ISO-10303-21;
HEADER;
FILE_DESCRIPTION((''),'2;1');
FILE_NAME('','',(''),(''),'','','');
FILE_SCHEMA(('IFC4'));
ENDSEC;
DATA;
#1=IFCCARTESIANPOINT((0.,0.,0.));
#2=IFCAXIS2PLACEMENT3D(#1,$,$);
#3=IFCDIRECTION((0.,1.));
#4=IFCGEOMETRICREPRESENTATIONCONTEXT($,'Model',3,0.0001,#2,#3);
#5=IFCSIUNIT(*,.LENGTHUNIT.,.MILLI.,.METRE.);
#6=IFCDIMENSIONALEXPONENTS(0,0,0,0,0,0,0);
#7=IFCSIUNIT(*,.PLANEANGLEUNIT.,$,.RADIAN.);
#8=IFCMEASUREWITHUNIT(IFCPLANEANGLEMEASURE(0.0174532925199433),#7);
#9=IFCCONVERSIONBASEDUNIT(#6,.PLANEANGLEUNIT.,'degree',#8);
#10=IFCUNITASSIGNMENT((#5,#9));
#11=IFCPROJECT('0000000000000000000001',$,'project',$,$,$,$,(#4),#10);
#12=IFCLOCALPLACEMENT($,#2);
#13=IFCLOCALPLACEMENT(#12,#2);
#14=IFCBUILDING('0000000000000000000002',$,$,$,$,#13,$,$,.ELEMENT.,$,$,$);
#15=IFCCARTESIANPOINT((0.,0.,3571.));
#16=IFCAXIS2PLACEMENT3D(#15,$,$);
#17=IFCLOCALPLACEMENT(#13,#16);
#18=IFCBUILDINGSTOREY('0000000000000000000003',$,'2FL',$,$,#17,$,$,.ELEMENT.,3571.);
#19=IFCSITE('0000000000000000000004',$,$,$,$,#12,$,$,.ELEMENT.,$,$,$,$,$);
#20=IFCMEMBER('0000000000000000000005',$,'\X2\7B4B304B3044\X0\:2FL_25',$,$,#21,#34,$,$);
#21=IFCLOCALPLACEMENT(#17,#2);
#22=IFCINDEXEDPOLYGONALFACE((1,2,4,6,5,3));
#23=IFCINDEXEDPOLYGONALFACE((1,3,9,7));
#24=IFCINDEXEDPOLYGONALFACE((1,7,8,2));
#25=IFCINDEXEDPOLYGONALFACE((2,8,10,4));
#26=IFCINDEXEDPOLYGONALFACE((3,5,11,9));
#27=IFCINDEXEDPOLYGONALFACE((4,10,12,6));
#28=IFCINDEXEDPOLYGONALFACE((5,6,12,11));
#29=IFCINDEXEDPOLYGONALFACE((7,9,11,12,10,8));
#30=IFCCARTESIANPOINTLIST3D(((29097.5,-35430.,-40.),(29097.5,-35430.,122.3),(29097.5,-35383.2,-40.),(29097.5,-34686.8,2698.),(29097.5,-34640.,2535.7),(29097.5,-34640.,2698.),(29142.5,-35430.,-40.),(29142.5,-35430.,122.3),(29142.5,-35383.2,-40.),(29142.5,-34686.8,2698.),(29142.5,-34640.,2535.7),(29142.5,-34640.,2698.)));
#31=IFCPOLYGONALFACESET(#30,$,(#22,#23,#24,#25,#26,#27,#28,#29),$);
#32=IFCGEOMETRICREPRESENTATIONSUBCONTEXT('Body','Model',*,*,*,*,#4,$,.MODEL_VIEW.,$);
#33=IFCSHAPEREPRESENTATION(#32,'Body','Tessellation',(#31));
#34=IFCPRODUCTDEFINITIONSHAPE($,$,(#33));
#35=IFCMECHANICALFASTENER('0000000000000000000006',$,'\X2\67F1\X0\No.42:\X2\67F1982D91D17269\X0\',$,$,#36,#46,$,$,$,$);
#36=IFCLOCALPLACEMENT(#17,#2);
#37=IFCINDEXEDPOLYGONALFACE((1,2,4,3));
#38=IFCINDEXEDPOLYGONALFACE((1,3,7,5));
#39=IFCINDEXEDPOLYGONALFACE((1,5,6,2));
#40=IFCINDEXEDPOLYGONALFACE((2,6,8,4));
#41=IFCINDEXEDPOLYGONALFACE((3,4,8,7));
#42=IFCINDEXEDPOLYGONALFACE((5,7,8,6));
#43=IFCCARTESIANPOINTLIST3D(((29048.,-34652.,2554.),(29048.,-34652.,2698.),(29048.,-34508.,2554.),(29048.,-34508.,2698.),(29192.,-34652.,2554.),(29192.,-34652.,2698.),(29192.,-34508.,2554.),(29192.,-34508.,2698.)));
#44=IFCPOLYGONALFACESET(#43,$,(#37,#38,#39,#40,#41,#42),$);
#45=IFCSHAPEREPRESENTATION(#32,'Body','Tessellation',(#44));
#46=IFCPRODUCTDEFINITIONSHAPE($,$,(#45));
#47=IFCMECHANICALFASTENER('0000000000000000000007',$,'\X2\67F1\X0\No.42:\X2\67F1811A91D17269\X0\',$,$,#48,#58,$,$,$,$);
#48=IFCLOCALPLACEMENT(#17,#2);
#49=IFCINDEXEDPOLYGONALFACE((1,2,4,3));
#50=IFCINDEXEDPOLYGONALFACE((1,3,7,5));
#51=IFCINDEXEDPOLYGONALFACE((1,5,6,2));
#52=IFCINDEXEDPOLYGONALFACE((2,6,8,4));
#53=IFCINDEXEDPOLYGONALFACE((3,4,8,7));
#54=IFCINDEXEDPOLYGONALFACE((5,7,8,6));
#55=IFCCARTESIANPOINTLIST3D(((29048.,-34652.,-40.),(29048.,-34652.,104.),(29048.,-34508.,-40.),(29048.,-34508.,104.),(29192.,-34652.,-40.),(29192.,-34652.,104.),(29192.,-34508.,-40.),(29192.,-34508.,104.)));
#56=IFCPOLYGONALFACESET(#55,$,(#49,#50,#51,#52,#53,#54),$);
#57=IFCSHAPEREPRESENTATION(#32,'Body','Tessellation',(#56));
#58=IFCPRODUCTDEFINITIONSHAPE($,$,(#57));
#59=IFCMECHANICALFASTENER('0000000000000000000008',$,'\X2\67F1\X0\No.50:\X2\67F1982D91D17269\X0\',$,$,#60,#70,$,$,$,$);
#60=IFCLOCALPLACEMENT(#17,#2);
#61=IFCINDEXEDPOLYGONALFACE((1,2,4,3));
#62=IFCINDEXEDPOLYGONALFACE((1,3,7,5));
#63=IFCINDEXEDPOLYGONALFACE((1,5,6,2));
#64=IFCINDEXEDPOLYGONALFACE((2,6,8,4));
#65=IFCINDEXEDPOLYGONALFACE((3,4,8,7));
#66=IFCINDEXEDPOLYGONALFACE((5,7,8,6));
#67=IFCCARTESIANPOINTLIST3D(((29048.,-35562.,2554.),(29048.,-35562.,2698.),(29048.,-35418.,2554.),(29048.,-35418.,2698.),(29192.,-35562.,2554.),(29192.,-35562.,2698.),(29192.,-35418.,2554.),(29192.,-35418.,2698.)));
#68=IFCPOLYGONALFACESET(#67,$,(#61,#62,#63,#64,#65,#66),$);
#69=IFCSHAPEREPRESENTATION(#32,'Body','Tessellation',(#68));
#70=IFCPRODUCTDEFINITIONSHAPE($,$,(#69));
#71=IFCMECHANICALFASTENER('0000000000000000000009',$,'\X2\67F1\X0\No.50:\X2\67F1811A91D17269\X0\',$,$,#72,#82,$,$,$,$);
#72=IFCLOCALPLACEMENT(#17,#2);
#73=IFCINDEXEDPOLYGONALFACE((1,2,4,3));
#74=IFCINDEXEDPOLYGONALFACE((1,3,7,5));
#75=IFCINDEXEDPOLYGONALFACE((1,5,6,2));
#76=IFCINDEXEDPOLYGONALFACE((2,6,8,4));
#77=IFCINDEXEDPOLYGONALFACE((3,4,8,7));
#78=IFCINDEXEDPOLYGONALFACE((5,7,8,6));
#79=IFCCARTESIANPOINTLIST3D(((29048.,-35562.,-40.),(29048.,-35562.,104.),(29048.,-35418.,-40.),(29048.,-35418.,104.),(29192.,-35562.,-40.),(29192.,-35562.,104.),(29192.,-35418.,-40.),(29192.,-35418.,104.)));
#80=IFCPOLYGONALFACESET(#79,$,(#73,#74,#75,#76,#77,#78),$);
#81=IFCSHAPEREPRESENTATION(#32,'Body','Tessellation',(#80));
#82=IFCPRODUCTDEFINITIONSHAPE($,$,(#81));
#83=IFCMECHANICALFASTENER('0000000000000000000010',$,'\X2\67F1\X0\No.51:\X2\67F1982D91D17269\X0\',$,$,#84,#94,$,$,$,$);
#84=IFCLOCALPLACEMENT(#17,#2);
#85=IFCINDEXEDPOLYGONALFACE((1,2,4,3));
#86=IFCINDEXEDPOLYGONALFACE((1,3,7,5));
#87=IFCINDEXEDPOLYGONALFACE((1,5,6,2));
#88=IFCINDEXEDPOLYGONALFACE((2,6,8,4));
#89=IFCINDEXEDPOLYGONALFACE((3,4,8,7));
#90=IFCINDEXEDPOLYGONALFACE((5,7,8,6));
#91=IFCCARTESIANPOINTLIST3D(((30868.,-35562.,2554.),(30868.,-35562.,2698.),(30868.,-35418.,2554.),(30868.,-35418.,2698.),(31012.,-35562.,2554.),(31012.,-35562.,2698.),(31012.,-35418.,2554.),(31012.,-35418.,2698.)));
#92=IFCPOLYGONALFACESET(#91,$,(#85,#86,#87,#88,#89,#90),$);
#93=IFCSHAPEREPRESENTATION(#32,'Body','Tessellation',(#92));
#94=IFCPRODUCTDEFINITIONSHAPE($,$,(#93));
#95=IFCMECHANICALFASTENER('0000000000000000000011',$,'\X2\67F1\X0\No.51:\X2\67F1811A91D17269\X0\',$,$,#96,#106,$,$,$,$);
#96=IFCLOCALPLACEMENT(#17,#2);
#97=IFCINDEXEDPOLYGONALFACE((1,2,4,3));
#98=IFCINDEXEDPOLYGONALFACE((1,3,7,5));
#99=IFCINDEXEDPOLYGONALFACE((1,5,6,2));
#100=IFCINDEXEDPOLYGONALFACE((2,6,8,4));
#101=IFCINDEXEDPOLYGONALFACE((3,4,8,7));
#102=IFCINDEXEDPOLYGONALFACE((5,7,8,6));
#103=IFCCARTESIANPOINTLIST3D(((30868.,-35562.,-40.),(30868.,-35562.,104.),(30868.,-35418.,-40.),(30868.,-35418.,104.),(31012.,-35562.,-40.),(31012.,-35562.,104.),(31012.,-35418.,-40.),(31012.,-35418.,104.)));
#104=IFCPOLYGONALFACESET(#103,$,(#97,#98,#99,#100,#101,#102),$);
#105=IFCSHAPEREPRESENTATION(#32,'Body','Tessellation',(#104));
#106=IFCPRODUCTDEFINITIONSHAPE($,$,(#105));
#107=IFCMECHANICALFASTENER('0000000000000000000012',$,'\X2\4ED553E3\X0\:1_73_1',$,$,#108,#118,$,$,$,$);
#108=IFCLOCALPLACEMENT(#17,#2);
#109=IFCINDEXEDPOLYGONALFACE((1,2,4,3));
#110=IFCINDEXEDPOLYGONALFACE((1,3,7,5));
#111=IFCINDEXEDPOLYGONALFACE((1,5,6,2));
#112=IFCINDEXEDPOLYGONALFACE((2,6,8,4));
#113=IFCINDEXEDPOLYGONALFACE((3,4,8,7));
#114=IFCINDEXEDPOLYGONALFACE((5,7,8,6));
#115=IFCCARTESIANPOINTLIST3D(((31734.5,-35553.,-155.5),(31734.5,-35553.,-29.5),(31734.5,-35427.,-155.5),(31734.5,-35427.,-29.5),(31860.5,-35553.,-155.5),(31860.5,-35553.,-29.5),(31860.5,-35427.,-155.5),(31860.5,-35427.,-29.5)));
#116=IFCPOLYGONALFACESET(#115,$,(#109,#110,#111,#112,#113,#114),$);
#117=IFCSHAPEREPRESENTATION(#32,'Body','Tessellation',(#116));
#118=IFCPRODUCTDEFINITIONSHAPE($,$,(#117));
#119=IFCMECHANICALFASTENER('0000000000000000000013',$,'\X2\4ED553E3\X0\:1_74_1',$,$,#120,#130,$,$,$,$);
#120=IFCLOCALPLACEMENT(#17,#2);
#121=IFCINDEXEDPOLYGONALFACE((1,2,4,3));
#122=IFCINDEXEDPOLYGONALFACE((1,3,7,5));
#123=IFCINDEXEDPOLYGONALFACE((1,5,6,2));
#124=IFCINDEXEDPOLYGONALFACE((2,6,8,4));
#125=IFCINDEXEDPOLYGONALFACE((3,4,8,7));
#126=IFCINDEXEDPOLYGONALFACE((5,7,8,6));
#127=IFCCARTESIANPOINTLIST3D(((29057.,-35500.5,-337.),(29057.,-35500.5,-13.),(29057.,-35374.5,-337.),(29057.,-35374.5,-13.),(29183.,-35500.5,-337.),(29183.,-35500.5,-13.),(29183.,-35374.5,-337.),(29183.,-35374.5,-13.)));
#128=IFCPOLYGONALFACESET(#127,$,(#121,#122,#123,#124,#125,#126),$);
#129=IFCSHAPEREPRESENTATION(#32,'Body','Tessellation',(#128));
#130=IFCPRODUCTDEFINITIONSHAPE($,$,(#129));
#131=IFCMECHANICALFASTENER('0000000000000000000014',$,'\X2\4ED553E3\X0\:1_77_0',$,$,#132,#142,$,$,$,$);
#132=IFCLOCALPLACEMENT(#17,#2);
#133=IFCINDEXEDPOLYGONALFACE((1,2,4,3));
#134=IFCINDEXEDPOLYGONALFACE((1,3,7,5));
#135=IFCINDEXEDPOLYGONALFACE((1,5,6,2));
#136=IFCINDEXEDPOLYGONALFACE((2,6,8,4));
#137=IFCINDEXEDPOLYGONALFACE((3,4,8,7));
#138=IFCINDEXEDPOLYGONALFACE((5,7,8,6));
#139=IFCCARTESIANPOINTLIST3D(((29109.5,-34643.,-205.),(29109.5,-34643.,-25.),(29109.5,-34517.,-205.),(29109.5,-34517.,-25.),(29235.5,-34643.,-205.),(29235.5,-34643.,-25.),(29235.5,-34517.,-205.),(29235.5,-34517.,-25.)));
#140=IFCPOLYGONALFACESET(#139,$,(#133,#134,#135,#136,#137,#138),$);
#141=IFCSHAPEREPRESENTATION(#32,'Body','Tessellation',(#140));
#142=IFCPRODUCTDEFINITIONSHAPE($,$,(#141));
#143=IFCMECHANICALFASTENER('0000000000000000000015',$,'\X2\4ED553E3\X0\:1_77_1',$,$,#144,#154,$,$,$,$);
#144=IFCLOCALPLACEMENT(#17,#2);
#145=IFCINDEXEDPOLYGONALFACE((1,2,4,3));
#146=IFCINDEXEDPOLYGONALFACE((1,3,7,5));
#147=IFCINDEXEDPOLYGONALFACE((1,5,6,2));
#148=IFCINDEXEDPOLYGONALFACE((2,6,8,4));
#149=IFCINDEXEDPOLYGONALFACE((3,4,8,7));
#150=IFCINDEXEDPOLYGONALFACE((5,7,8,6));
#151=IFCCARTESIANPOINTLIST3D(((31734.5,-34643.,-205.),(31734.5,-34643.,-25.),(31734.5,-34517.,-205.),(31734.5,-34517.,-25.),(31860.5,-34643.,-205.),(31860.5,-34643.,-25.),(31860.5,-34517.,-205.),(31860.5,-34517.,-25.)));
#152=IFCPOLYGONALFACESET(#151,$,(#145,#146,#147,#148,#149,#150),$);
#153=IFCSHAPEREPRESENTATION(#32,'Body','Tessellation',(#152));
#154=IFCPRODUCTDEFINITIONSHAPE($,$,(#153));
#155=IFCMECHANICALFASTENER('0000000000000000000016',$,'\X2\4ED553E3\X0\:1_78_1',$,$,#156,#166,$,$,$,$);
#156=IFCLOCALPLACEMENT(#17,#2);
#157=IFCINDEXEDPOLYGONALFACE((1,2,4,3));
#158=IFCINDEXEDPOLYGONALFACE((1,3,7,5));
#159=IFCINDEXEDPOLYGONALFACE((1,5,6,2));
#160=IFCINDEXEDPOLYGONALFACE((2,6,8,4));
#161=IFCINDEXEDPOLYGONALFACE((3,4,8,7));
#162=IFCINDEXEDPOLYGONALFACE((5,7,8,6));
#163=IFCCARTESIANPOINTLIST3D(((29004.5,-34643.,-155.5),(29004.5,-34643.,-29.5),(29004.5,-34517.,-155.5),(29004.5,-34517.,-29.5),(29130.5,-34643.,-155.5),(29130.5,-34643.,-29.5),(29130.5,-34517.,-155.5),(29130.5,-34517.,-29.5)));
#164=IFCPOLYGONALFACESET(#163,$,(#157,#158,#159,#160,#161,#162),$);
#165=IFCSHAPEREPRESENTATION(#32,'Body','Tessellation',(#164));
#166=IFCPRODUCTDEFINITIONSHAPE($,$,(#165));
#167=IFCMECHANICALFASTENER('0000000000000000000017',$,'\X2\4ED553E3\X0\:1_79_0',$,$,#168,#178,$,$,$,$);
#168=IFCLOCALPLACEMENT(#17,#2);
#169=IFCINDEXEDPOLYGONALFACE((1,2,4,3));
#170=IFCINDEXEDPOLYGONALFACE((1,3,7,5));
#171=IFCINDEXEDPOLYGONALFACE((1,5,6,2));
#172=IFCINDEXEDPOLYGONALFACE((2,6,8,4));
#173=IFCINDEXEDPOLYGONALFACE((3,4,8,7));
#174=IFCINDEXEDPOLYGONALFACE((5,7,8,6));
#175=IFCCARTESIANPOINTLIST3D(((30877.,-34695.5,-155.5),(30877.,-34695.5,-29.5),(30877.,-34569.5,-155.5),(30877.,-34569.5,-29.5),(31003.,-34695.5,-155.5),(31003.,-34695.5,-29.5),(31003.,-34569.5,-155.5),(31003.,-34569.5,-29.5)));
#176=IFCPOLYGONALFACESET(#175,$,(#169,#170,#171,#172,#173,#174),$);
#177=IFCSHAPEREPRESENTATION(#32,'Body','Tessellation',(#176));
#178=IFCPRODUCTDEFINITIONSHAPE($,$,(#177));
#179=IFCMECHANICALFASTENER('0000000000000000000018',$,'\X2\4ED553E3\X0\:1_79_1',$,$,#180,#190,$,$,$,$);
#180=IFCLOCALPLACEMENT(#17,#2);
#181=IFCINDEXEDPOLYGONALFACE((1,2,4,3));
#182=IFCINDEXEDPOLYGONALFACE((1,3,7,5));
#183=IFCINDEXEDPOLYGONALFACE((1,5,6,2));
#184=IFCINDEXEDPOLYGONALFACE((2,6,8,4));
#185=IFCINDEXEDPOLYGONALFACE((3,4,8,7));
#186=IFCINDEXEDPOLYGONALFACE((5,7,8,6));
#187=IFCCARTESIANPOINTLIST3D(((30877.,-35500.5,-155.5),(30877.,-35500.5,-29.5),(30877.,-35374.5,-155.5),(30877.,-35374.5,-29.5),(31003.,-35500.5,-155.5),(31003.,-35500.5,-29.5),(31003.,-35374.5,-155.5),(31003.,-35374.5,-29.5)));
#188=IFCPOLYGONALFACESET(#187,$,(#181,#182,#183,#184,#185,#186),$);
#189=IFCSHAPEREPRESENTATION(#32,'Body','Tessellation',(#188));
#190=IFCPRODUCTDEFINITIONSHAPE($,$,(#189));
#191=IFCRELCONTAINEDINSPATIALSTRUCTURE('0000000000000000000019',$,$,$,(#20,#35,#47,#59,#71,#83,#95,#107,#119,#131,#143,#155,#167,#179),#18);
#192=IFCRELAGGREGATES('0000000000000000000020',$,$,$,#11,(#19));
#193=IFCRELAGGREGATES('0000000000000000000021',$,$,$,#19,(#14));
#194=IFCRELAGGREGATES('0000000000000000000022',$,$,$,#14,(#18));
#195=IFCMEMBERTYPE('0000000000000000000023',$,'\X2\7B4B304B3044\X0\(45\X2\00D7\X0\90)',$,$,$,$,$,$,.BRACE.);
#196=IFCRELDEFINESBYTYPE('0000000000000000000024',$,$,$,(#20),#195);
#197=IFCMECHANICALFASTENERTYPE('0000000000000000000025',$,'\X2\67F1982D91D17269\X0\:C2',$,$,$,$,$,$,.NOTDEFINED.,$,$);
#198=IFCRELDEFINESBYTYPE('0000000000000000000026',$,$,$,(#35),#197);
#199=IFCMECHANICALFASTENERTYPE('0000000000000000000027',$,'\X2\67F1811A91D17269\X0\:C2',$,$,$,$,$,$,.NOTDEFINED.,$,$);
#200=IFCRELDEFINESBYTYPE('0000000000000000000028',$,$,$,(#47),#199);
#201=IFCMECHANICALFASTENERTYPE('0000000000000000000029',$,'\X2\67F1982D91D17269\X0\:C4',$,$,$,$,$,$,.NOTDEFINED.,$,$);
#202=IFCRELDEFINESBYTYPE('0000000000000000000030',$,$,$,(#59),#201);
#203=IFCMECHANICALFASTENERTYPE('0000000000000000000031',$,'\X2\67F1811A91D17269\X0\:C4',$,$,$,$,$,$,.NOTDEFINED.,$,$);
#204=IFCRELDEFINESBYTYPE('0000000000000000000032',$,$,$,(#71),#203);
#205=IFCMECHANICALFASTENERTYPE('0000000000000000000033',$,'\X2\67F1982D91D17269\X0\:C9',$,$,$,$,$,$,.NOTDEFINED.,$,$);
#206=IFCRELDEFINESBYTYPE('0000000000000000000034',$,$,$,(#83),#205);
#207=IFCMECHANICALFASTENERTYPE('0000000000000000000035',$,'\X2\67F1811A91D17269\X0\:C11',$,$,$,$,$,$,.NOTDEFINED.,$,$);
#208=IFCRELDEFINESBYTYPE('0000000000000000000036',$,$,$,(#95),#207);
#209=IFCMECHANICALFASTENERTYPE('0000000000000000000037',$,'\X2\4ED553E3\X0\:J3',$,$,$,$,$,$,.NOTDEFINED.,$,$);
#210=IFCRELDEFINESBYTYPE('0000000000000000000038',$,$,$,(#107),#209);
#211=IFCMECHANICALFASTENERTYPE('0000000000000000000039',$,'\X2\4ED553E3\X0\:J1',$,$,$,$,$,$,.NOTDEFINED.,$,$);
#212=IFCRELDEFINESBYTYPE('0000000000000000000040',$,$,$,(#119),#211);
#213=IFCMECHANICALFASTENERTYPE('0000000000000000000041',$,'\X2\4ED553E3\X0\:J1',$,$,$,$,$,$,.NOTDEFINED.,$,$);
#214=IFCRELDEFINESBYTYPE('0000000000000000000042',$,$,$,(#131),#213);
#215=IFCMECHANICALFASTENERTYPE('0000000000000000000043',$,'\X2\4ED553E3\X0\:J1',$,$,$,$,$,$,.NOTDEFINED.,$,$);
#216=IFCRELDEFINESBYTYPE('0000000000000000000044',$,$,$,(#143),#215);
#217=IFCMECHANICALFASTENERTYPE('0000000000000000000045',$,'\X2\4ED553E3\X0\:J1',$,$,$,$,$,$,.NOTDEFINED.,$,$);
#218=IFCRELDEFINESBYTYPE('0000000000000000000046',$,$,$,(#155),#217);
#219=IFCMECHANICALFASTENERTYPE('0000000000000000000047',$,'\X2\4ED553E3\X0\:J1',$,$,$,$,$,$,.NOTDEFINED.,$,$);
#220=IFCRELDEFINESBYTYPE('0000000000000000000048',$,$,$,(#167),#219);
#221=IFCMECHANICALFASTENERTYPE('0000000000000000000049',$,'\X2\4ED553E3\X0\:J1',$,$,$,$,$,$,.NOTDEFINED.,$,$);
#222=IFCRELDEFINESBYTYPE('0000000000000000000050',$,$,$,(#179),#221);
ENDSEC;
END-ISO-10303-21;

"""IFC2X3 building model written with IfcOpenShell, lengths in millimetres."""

from ifc_helpers import new_model, entity, si_unit, converted_unit, direction, frame, origin, origin_with_axes, origin_2d, place, context, subcontext, project, spatial, polyline, rectangle, outline, extrude, type_object, element, save


model = new_model("IFC2X3")

# Units and contexts
model_context = context("Model", 3, precision=0.0001, world=origin(), true_north=direction((0.0, 1.0)))
body_context = subcontext(model_context, "Body", "Model", "MODEL_VIEW")
ifc_project = project(units=[si_unit("LENGTHUNIT", "METRE", prefix="MILLI"), converted_unit("PLANEANGLEUNIT", "degree", entity("IfcPlaneAngleMeasure", 0.0174532925199433), si_unit("PLANEANGLEUNIT", "RADIAN"), dimensions=[0, 0, 0, 0, 0, 0, 0])], contexts=[model_context])

# Site, building, storey
site_placement = place(None, origin())
site = spatial("IfcSite", under=ifc_project, at=site_placement, CompositionType="ELEMENT")
building_placement = place(site_placement, origin())
building = spatial("IfcBuilding", under=site, at=building_placement, CompositionType="ELEMENT")
storey_placement = place(building_placement, frame((0.0, 0.0, 3571.0)))
storey = spatial("IfcBuildingStorey", under=building, at=storey_placement, Name="2FL", CompositionType="ELEMENT", Elevation=3571.0)

# Member
member_type_1 = type_object("IfcMemberType", Name="筋かい(45×90)", PredefinedType="BRACE")
member_1_placement = place(storey_placement, frame((29120.0, -35430.0, -40.0), z_axis=(0.0, 0.277223, 0.960806), x_axis=(0.0, -0.960806, 0.277223)))
element("IfcMember", 1, at=member_1_placement, inside=storey, type_object=member_type_1, Name="筋かい:2FL_25", context=body_context, shape_type="SweptSolid", body=[
    extrude(outline(polyline([(0.0, 0.0), (13.0, -45.0), (2693.7, -45.0), (2849.7, 0.0), (2836.7, 45.0), (156.0, 45.0), (0.0, 0.0)])), frame((0.0, -22.5, 0.0), z_axis=(0.0, 1.0, 0.0), x_axis=(0.0, 0.0, 1.0)), (0.0, 0.0, 1.0), 45.0),
])

# Mechanical fasteners
mechanical_fastener_type_1 = type_object("IfcMechanicalFastenerType", Name="柱頭金物:C2")
mechanical_fastener_1_placement = place(storey_placement, frame((29120.0, -34580.0, 2554.0)))
element("IfcMechanicalFastener", 2, at=mechanical_fastener_1_placement, inside=storey, type_object=mechanical_fastener_type_1, Name="柱No.42:柱頭金物", context=body_context, shape_type="SweptSolid", body=[
    extrude(rectangle(XDim=144.0, YDim=144.0, at=origin_2d()), origin_with_axes(), (0.0, 0.0, 1.0), 144.0),
])
mechanical_fastener_type_2 = type_object("IfcMechanicalFastenerType", Name="柱脚金物:C2")
mechanical_fastener_2_placement = place(storey_placement, frame((29120.0, -34580.0, -40.0)))
element("IfcMechanicalFastener", 3, at=mechanical_fastener_2_placement, inside=storey, type_object=mechanical_fastener_type_2, Name="柱No.42:柱脚金物", context=body_context, shape_type="SweptSolid", body=[
    extrude(rectangle(XDim=144.0, YDim=144.0, at=origin_2d()), origin_with_axes(), (0.0, 0.0, 1.0), 144.0),
])
mechanical_fastener_type_3 = type_object("IfcMechanicalFastenerType", Name="柱頭金物:C4")
mechanical_fastener_3_placement = place(storey_placement, frame((29120.0, -35490.0, 2554.0)))
element("IfcMechanicalFastener", 4, at=mechanical_fastener_3_placement, inside=storey, type_object=mechanical_fastener_type_3, Name="柱No.50:柱頭金物", context=body_context, shape_type="SweptSolid", body=[
    extrude(rectangle(XDim=144.0, YDim=144.0, at=origin_2d()), origin_with_axes(), (0.0, 0.0, 1.0), 144.0),
])
mechanical_fastener_type_4 = type_object("IfcMechanicalFastenerType", Name="柱脚金物:C4")
mechanical_fastener_4_placement = place(storey_placement, frame((29120.0, -35490.0, -40.0)))
element("IfcMechanicalFastener", 5, at=mechanical_fastener_4_placement, inside=storey, type_object=mechanical_fastener_type_4, Name="柱No.50:柱脚金物", context=body_context, shape_type="SweptSolid", body=[
    extrude(rectangle(XDim=144.0, YDim=144.0, at=origin_2d()), origin_with_axes(), (0.0, 0.0, 1.0), 144.0),
])
mechanical_fastener_type_5 = type_object("IfcMechanicalFastenerType", Name="柱頭金物:C9")
mechanical_fastener_5_placement = place(storey_placement, frame((30940.0, -35490.0, 2554.0)))
element("IfcMechanicalFastener", 6, at=mechanical_fastener_5_placement, inside=storey, type_object=mechanical_fastener_type_5, Name="柱No.51:柱頭金物", context=body_context, shape_type="SweptSolid", body=[
    extrude(rectangle(XDim=144.0, YDim=144.0, at=origin_2d()), origin_with_axes(), (0.0, 0.0, 1.0), 144.0),
])
mechanical_fastener_type_6 = type_object("IfcMechanicalFastenerType", Name="柱脚金物:C11")
mechanical_fastener_6_placement = place(storey_placement, frame((30940.0, -35490.0, -40.0)))
element("IfcMechanicalFastener", 7, at=mechanical_fastener_6_placement, inside=storey, type_object=mechanical_fastener_type_6, Name="柱No.51:柱脚金物", context=body_context, shape_type="SweptSolid", body=[
    extrude(rectangle(XDim=144.0, YDim=144.0, at=origin_2d()), origin_with_axes(), (0.0, 0.0, 1.0), 144.0),
])
mechanical_fastener_type_7 = type_object("IfcMechanicalFastenerType", Name="仕口:J3")
mechanical_fastener_7_placement = place(storey_placement, frame((31797.5, -35490.0, -155.5)))
element("IfcMechanicalFastener", 8, at=mechanical_fastener_7_placement, inside=storey, type_object=mechanical_fastener_type_7, Name="仕口:1_73_1", context=body_context, shape_type="SweptSolid", body=[
    extrude(rectangle(XDim=126.0, YDim=126.0, at=origin_2d()), origin_with_axes(), (0.0, 0.0, 1.0), 126.0),
])
mechanical_fastener_type_8 = type_object("IfcMechanicalFastenerType", Name="仕口:J1")
mechanical_fastener_8_placement = place(storey_placement, frame((29120.0, -35437.5, -337.0)))
element("IfcMechanicalFastener", 9, at=mechanical_fastener_8_placement, inside=storey, type_object=mechanical_fastener_type_8, Name="仕口:1_74_1", context=body_context, shape_type="SweptSolid", body=[
    extrude(rectangle(XDim=126.0, YDim=126.0, at=origin_2d()), origin_with_axes(), (0.0, 0.0, 1.0), 324.0),
])
mechanical_fastener_type_9 = type_object("IfcMechanicalFastenerType", Name="仕口:J1")
mechanical_fastener_9_placement = place(storey_placement, frame((29172.5, -34580.0, -205.0)))
element("IfcMechanicalFastener", 10, at=mechanical_fastener_9_placement, inside=storey, type_object=mechanical_fastener_type_9, Name="仕口:1_77_0", context=body_context, shape_type="SweptSolid", body=[
    extrude(rectangle(XDim=126.0, YDim=126.0, at=origin_2d()), origin_with_axes(), (0.0, 0.0, 1.0), 180.0),
])
mechanical_fastener_type_10 = type_object("IfcMechanicalFastenerType", Name="仕口:J1")
mechanical_fastener_10_placement = place(storey_placement, frame((31797.5, -34580.0, -205.0)))
element("IfcMechanicalFastener", 11, at=mechanical_fastener_10_placement, inside=storey, type_object=mechanical_fastener_type_10, Name="仕口:1_77_1", context=body_context, shape_type="SweptSolid", body=[
    extrude(rectangle(XDim=126.0, YDim=126.0, at=origin_2d()), origin_with_axes(), (0.0, 0.0, 1.0), 180.0),
])
mechanical_fastener_type_11 = type_object("IfcMechanicalFastenerType", Name="仕口:J1")
mechanical_fastener_11_placement = place(storey_placement, frame((29067.5, -34580.0, -155.5)))
element("IfcMechanicalFastener", 12, at=mechanical_fastener_11_placement, inside=storey, type_object=mechanical_fastener_type_11, Name="仕口:1_78_1", context=body_context, shape_type="SweptSolid", body=[
    extrude(rectangle(XDim=126.0, YDim=126.0, at=origin_2d()), origin_with_axes(), (0.0, 0.0, 1.0), 126.0),
])
mechanical_fastener_type_12 = type_object("IfcMechanicalFastenerType", Name="仕口:J1")
mechanical_fastener_12_placement = place(storey_placement, frame((30940.0, -34632.5, -155.5)))
element("IfcMechanicalFastener", 13, at=mechanical_fastener_12_placement, inside=storey, type_object=mechanical_fastener_type_12, Name="仕口:1_79_0", context=body_context, shape_type="SweptSolid", body=[
    extrude(rectangle(XDim=126.0, YDim=126.0, at=origin_2d()), origin_with_axes(), (0.0, 0.0, 1.0), 126.0),
])
mechanical_fastener_type_13 = type_object("IfcMechanicalFastenerType", Name="仕口:J1")
mechanical_fastener_13_placement = place(storey_placement, frame((30940.0, -35437.5, -155.5)))
element("IfcMechanicalFastener", 14, at=mechanical_fastener_13_placement, inside=storey, type_object=mechanical_fastener_type_13, Name="仕口:1_79_1", context=body_context, shape_type="SweptSolid", body=[
    extrude(rectangle(XDim=126.0, YDim=126.0, at=origin_2d()), origin_with_axes(), (0.0, 0.0, 1.0), 126.0),
])

save(model, "model.ifc")
